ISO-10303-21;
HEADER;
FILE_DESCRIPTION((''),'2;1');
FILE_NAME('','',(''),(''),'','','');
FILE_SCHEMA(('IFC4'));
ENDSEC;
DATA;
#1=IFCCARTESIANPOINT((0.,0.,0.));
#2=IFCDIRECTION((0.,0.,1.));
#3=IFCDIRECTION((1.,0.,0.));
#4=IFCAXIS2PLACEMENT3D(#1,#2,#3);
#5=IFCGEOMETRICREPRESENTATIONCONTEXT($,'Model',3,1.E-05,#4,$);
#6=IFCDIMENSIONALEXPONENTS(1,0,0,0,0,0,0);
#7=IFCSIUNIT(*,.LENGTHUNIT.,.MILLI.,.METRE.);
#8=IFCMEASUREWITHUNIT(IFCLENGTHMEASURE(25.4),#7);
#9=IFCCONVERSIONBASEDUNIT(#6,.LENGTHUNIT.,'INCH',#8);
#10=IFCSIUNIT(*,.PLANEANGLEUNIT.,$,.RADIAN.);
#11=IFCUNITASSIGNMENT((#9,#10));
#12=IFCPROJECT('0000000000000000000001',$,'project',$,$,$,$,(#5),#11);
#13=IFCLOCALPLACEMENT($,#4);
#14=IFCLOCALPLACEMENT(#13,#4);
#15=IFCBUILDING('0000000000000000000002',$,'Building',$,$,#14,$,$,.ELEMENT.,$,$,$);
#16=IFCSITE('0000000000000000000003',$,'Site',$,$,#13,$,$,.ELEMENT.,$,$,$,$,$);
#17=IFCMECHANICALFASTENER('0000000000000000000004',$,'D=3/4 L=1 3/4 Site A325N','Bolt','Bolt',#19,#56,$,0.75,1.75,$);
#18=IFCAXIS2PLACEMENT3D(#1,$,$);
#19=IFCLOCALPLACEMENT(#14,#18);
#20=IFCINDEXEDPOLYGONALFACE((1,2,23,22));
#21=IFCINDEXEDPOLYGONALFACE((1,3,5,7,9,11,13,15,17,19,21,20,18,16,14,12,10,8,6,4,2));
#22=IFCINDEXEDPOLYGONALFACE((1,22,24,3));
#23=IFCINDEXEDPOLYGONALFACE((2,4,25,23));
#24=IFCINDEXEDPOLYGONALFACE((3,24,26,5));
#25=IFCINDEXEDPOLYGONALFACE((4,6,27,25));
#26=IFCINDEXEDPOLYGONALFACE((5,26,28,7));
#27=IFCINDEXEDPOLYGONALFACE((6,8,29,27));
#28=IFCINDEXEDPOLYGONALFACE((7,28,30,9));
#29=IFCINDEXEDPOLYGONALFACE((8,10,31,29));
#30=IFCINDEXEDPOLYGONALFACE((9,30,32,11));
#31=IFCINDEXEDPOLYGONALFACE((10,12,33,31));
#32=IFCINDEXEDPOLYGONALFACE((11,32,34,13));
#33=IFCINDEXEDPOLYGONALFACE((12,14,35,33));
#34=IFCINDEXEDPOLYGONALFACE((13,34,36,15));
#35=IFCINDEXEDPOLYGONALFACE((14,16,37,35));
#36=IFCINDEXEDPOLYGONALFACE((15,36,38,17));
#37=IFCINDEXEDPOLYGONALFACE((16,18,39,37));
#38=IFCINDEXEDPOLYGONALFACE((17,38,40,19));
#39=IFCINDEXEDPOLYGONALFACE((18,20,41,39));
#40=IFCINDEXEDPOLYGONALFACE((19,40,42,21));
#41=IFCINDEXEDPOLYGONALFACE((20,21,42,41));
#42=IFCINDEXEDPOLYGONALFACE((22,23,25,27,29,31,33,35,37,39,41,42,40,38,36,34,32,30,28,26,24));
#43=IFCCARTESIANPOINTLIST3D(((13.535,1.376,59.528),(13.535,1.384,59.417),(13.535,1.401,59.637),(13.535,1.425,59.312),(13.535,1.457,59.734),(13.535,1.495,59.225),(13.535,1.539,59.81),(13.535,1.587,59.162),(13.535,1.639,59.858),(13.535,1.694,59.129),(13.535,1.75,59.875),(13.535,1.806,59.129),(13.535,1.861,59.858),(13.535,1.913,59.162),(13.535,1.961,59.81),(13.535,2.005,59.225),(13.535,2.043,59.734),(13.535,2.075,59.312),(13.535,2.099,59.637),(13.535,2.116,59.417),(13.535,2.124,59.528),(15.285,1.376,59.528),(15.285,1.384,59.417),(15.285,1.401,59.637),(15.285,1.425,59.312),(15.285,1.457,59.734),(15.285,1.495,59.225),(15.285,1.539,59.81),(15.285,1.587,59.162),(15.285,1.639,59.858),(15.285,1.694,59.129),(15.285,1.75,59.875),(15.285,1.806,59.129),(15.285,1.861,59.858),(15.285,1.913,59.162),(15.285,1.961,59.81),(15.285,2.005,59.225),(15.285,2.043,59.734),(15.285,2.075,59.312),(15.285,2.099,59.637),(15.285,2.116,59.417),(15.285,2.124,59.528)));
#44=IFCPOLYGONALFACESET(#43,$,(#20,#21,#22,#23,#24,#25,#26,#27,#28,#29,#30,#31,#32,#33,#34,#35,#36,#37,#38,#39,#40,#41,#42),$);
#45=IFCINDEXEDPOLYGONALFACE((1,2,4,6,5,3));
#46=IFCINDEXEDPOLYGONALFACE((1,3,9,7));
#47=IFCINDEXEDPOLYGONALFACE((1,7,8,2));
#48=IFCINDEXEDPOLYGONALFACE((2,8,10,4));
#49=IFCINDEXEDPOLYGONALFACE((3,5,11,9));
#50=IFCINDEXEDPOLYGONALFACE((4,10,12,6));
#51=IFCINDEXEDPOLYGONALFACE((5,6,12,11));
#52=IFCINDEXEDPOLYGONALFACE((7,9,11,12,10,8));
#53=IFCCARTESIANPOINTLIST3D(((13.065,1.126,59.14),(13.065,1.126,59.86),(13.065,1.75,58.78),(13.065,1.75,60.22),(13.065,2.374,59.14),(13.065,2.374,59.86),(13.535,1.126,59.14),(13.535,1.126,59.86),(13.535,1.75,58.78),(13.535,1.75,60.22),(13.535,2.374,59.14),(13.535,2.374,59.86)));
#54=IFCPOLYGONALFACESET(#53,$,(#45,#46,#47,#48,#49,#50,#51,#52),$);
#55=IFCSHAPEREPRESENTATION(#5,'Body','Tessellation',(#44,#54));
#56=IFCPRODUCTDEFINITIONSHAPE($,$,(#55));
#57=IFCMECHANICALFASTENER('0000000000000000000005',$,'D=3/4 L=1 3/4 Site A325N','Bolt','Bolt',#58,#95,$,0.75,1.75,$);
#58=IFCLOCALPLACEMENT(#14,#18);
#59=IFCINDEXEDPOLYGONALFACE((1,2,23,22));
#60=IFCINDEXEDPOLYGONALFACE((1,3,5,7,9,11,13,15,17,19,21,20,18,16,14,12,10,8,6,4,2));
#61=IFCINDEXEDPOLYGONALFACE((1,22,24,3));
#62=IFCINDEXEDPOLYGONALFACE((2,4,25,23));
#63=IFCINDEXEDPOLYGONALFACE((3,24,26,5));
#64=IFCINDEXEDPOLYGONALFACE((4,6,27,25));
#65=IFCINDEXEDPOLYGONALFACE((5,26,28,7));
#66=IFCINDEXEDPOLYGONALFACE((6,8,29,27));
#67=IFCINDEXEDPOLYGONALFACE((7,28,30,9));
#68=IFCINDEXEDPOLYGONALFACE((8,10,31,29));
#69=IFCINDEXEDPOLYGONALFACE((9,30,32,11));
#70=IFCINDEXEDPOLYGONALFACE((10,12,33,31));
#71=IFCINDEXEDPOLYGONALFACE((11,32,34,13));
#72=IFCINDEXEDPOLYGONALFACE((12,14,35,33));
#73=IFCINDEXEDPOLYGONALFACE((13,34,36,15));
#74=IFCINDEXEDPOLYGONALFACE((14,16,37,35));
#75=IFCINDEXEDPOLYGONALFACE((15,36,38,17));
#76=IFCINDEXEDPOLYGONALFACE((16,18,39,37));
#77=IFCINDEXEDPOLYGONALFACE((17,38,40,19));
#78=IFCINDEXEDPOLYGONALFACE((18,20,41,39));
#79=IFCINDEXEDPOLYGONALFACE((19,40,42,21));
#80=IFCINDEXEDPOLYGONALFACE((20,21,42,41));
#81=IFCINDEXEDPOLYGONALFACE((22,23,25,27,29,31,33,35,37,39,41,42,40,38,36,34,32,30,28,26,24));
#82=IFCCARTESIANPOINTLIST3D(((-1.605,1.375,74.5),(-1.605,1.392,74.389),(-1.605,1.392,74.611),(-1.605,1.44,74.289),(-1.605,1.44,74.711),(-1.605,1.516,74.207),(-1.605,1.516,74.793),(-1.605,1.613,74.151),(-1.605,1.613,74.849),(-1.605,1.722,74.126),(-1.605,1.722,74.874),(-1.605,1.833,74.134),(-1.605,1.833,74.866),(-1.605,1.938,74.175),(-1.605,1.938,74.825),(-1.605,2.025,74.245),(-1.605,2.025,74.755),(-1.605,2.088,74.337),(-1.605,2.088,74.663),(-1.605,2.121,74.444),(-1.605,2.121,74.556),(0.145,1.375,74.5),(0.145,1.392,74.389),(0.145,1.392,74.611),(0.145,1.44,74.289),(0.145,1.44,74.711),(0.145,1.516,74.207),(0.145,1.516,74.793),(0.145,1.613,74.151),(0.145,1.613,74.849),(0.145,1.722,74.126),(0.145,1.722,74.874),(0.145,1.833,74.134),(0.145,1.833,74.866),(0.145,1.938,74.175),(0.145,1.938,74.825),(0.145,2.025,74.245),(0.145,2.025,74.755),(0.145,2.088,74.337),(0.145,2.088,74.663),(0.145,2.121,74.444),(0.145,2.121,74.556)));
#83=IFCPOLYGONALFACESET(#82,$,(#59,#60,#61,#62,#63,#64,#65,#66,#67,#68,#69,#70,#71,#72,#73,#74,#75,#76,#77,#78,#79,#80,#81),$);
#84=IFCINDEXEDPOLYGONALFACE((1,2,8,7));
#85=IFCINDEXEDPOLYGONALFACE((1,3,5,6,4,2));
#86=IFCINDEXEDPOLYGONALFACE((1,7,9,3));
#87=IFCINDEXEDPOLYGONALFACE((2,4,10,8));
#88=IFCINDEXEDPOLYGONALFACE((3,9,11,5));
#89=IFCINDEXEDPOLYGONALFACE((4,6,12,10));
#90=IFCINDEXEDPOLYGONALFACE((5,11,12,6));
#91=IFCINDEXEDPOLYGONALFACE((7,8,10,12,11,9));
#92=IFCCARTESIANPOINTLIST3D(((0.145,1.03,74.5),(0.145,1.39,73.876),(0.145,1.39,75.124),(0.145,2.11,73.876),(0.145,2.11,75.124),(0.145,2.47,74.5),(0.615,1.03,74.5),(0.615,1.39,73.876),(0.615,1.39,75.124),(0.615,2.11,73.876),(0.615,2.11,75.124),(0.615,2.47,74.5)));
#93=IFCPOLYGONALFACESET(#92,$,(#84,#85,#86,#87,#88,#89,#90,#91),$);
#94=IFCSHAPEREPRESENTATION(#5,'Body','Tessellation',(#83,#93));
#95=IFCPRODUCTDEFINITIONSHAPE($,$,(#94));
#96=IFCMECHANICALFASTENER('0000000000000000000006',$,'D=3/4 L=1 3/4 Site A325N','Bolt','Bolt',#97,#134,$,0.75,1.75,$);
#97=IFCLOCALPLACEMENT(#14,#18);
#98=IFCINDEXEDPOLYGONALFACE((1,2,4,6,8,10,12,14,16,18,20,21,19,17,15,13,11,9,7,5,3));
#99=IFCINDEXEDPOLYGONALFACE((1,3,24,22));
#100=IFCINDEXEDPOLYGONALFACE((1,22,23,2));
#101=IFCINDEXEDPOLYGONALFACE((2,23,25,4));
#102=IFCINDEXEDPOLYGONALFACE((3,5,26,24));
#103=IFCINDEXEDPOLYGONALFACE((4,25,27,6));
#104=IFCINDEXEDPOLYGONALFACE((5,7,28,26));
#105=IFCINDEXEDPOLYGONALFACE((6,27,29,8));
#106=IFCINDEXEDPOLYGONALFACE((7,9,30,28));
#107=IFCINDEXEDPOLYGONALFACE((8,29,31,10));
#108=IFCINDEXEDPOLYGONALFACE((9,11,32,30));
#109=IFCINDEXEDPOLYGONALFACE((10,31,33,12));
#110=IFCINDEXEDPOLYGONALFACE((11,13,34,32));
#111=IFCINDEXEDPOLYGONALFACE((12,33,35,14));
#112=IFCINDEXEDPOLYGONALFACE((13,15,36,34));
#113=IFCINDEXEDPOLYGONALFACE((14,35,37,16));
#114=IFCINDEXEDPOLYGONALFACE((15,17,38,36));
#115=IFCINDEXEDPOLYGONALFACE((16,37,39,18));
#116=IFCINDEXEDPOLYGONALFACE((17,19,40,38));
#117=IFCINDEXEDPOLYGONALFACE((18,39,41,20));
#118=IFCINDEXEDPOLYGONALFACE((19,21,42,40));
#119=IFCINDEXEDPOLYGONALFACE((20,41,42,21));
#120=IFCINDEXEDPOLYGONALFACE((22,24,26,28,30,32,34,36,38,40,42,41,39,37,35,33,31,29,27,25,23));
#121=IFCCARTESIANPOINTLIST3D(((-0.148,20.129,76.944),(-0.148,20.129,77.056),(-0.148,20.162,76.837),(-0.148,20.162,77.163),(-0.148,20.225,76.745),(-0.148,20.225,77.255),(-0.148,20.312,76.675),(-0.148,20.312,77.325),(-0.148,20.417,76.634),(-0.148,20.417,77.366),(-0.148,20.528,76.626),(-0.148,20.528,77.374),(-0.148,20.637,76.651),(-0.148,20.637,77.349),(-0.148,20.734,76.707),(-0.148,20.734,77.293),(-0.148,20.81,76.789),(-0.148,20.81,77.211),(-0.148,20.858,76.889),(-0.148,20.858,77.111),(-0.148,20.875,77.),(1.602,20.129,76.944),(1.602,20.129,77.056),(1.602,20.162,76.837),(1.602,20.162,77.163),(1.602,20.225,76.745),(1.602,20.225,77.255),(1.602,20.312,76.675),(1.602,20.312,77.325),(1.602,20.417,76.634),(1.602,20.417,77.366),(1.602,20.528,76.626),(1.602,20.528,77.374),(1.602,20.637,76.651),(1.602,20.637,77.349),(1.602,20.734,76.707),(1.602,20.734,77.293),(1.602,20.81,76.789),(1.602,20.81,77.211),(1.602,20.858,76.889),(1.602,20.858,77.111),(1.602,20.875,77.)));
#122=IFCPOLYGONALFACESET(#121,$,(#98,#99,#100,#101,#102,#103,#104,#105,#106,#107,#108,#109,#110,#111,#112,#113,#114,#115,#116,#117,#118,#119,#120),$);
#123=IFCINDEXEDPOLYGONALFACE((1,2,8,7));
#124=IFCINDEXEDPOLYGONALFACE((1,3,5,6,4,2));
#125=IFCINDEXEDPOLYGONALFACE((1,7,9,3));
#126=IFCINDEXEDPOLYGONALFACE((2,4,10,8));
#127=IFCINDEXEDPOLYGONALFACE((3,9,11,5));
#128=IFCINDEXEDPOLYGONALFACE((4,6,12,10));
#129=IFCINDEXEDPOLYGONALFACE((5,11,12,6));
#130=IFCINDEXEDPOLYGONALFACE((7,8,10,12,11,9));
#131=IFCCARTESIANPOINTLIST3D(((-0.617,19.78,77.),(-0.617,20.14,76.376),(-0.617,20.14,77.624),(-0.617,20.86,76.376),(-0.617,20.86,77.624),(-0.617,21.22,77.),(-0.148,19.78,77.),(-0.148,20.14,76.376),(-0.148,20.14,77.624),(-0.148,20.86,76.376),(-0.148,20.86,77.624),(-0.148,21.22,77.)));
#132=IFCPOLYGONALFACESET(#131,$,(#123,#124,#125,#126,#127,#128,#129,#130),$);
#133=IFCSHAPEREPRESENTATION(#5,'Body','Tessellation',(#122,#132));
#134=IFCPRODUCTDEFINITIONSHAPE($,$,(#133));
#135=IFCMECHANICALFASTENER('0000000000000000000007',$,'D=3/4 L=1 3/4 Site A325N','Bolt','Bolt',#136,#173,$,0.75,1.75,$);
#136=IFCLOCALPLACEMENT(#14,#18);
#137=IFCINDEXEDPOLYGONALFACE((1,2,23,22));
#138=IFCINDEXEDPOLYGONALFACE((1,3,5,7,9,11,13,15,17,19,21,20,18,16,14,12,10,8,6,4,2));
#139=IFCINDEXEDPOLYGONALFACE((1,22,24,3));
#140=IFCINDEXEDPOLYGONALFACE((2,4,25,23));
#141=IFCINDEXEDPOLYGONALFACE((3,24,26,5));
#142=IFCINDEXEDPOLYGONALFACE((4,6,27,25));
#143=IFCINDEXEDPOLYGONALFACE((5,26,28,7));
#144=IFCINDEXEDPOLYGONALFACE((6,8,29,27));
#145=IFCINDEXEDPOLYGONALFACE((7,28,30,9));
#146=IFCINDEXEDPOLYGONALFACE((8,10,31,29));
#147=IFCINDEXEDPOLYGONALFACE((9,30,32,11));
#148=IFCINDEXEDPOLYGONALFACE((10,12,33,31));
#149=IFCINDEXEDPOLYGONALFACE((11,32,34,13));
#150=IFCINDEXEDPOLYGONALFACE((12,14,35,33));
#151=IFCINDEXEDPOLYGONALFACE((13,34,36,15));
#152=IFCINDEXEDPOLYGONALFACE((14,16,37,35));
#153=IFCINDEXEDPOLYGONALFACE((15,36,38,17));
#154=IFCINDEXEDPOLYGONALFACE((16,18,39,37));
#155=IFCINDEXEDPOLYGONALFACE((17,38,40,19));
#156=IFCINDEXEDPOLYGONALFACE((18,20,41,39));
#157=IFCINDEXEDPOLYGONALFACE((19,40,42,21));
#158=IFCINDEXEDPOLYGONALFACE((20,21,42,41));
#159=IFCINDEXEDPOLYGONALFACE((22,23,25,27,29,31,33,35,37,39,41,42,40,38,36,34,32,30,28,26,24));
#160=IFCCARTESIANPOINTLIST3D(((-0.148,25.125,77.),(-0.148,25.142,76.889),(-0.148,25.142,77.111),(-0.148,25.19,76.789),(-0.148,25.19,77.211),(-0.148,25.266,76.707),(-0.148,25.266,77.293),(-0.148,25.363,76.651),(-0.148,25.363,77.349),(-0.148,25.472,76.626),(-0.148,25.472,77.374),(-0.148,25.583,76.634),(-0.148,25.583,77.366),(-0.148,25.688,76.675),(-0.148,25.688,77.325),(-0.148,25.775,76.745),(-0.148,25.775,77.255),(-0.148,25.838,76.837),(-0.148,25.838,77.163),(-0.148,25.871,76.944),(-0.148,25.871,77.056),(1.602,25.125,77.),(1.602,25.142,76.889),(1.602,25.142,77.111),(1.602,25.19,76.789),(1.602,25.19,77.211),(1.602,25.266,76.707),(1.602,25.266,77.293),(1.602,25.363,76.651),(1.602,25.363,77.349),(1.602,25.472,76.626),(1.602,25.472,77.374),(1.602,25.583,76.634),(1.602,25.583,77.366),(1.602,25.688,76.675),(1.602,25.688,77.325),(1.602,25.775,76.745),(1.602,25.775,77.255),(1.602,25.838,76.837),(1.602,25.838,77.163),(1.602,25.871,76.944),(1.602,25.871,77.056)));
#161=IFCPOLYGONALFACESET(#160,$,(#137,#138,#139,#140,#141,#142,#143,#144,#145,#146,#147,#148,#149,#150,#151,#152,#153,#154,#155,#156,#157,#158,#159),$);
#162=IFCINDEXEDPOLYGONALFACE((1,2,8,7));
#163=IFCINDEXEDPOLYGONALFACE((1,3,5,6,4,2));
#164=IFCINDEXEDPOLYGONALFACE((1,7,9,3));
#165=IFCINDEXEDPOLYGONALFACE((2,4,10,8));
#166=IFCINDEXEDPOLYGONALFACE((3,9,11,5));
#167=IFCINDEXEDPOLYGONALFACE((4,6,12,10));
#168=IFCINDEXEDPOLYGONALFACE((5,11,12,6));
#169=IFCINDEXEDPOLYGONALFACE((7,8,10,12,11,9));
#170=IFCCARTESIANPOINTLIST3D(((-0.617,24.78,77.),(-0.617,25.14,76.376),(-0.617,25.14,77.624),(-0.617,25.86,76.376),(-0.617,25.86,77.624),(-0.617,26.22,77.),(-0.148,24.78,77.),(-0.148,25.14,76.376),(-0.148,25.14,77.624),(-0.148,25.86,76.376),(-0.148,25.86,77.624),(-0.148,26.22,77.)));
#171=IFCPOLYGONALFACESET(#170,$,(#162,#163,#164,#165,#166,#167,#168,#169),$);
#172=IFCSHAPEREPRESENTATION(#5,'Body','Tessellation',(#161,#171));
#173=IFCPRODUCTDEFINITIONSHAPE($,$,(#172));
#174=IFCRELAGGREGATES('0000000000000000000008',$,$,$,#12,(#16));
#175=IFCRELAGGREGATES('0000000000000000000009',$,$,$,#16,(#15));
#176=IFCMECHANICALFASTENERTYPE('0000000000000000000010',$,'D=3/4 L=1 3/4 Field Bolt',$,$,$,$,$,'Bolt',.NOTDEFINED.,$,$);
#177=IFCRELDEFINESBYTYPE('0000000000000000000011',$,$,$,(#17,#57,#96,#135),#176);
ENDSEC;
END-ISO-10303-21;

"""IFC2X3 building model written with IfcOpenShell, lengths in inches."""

from ifc_helpers import new_model, entity, si_unit, converted_unit, frame, origin_with_axes, origin_2d_with_axis, place, context, project, spatial, polyline, circle, outline, extrude, source, transform, mapped, type_object, type_shapes, element, save


model = new_model("IFC2X3")

# Units and contexts
model_context = context("Model", 3, precision=1e-05, world=origin_with_axes())
ifc_project = project(units=[converted_unit("LENGTHUNIT", "INCH", entity("IfcLengthMeasure", 25.4), si_unit("LENGTHUNIT", "METRE", prefix="MILLI"), dimensions=[1, 0, 0, 0, 0, 0, 0]), si_unit("PLANEANGLEUNIT", "RADIAN")], contexts=[model_context])

# Site, building
site_placement = place(None, origin_with_axes())
site = spatial("IfcSite", under=ifc_project, at=site_placement, Name="Site", CompositionType="ELEMENT")
building_placement = place(site_placement, origin_with_axes())
building = spatial("IfcBuilding", under=site, at=building_placement, Name="Building", CompositionType="ELEMENT")

# Mechanical fasteners
mechanical_fastener_type_1 = type_object("IfcMechanicalFastenerType", Name="D=3/4 L=1 3/4 Field Bolt", ElementType="Bolt")
shared_shape_1 = source(origin_with_axes(), model_context, "Body", "SweptSolid", [
    extrude(circle(Radius=0.375, at=origin_2d_with_axis()), frame((0.0, 0.0, 0.0), z_axis=(1.0, 0.0, 0.0), x_axis=(0.0, 1.0, 0.0)), (0.0, 0.0, 1.0), 1.75),
    extrude(outline(polyline([(-0.72, 0.0), (-0.36, 0.624), (0.36, 0.624), (0.72, 0.0), (0.36, -0.624), (-0.36, -0.624), (-0.72, 0.0)])), frame((0.0, 0.0, 0.0), z_axis=(1.0, 0.0, 0.0), x_axis=(0.0, 1.0, 0.0)), (0.0, 0.0, -1.0), 0.47),
])
type_shapes(mechanical_fastener_type_1, [shared_shape_1])
placement_1 = place(building_placement, frame((36.0, 0.0, 58.0), z_axis=(0.0, 0.0, 1.0), x_axis=(-1.0, 0.0, 0.0)))
placement_2 = place(placement_1, frame((22.465, 1.75, 1.5), z_axis=(0.0, 1.0, 0.0), x_axis=(-1.0, 0.0, 0.0)))
for number, where, z_axis, x_axis, name in (
    (1, (0.0, 0.0, -3.5), (0.0, 0.0, 1.0), (1.0, 0.0, 0.0), "D=3/4 L=1 3/4 Site A325N"),
):
    element("IfcMechanicalFastener", number, at=place(placement_2, frame(where, z_axis=z_axis, x_axis=x_axis)), type_object=mechanical_fastener_type_1, Name=name, Description="Bolt", ObjectType="Bolt", NominalDiameter=0.75, NominalLength=1.75, context=model_context, shape_type="MappedRepresentation", body=[
        mapped(shared_shape_1, transform((0.0, 0.0, 0.0), scale=1.0)),
    ])
placement_3 = place(building_placement, frame((0.0, 0.0, 80.0), z_axis=(0.0, 0.0, 1.0), x_axis=(-1.0, 0.0, 0.0)))
placement_4 = place(placement_3, frame((-0.145, -1.75, -11.5), z_axis=(0.0, 0.0, 1.0), x_axis=(1.0, 0.0, 0.0)))
mechanical_fastener_1_placement = place(placement_4, frame((0.0, 0.0, 6.0), z_axis=(0.0, 0.0, 1.0), x_axis=(1.0, 0.0, 0.0)))
element("IfcMechanicalFastener", 2, at=mechanical_fastener_1_placement, type_object=mechanical_fastener_type_1, Name="D=3/4 L=1 3/4 Site A325N", Description="Bolt", ObjectType="Bolt", NominalDiameter=0.75, NominalLength=1.75, context=model_context, shape_type="MappedRepresentation", body=[
    mapped(shared_shape_1, transform((0.0, 0.0, 0.0), scale=1.0)),
])
placement_5 = place(building_placement, frame((0.0, 23.0, 82.5), z_axis=(0.0, 0.0, 1.0), x_axis=(1.0, 0.0, 0.0)))
placement_6 = place(placement_5, frame((-0.148, -2.5, -8.5), z_axis=(0.0, 0.0, 1.0), x_axis=(1.0, 0.0, 0.0)))
mechanical_fastener_2_placement = place(placement_6, frame((0.0, 0.0, 3.0), z_axis=(0.0, 0.0, 1.0), x_axis=(1.0, 0.0, 0.0)))
element("IfcMechanicalFastener", 3, at=mechanical_fastener_2_placement, type_object=mechanical_fastener_type_1, Name="D=3/4 L=1 3/4 Site A325N", Description="Bolt", ObjectType="Bolt", NominalDiameter=0.75, NominalLength=1.75, context=model_context, shape_type="MappedRepresentation", body=[
    mapped(shared_shape_1, transform((0.0, 0.0, 0.0), scale=1.0)),
])
placement_7 = place(placement_5, frame((-0.148, 2.5, -5.5), z_axis=(0.0, 0.0, -1.0), x_axis=(1.0, 0.0, 0.0)))
mechanical_fastener_3_placement = place(placement_7, origin_with_axes())
element("IfcMechanicalFastener", 4, at=mechanical_fastener_3_placement, type_object=mechanical_fastener_type_1, Name="D=3/4 L=1 3/4 Site A325N", Description="Bolt", ObjectType="Bolt", NominalDiameter=0.75, NominalLength=1.75, context=model_context, shape_type="MappedRepresentation", body=[
    mapped(shared_shape_1, transform((0.0, 0.0, 0.0), scale=1.0)),
])

save(model, "model.ifc")
